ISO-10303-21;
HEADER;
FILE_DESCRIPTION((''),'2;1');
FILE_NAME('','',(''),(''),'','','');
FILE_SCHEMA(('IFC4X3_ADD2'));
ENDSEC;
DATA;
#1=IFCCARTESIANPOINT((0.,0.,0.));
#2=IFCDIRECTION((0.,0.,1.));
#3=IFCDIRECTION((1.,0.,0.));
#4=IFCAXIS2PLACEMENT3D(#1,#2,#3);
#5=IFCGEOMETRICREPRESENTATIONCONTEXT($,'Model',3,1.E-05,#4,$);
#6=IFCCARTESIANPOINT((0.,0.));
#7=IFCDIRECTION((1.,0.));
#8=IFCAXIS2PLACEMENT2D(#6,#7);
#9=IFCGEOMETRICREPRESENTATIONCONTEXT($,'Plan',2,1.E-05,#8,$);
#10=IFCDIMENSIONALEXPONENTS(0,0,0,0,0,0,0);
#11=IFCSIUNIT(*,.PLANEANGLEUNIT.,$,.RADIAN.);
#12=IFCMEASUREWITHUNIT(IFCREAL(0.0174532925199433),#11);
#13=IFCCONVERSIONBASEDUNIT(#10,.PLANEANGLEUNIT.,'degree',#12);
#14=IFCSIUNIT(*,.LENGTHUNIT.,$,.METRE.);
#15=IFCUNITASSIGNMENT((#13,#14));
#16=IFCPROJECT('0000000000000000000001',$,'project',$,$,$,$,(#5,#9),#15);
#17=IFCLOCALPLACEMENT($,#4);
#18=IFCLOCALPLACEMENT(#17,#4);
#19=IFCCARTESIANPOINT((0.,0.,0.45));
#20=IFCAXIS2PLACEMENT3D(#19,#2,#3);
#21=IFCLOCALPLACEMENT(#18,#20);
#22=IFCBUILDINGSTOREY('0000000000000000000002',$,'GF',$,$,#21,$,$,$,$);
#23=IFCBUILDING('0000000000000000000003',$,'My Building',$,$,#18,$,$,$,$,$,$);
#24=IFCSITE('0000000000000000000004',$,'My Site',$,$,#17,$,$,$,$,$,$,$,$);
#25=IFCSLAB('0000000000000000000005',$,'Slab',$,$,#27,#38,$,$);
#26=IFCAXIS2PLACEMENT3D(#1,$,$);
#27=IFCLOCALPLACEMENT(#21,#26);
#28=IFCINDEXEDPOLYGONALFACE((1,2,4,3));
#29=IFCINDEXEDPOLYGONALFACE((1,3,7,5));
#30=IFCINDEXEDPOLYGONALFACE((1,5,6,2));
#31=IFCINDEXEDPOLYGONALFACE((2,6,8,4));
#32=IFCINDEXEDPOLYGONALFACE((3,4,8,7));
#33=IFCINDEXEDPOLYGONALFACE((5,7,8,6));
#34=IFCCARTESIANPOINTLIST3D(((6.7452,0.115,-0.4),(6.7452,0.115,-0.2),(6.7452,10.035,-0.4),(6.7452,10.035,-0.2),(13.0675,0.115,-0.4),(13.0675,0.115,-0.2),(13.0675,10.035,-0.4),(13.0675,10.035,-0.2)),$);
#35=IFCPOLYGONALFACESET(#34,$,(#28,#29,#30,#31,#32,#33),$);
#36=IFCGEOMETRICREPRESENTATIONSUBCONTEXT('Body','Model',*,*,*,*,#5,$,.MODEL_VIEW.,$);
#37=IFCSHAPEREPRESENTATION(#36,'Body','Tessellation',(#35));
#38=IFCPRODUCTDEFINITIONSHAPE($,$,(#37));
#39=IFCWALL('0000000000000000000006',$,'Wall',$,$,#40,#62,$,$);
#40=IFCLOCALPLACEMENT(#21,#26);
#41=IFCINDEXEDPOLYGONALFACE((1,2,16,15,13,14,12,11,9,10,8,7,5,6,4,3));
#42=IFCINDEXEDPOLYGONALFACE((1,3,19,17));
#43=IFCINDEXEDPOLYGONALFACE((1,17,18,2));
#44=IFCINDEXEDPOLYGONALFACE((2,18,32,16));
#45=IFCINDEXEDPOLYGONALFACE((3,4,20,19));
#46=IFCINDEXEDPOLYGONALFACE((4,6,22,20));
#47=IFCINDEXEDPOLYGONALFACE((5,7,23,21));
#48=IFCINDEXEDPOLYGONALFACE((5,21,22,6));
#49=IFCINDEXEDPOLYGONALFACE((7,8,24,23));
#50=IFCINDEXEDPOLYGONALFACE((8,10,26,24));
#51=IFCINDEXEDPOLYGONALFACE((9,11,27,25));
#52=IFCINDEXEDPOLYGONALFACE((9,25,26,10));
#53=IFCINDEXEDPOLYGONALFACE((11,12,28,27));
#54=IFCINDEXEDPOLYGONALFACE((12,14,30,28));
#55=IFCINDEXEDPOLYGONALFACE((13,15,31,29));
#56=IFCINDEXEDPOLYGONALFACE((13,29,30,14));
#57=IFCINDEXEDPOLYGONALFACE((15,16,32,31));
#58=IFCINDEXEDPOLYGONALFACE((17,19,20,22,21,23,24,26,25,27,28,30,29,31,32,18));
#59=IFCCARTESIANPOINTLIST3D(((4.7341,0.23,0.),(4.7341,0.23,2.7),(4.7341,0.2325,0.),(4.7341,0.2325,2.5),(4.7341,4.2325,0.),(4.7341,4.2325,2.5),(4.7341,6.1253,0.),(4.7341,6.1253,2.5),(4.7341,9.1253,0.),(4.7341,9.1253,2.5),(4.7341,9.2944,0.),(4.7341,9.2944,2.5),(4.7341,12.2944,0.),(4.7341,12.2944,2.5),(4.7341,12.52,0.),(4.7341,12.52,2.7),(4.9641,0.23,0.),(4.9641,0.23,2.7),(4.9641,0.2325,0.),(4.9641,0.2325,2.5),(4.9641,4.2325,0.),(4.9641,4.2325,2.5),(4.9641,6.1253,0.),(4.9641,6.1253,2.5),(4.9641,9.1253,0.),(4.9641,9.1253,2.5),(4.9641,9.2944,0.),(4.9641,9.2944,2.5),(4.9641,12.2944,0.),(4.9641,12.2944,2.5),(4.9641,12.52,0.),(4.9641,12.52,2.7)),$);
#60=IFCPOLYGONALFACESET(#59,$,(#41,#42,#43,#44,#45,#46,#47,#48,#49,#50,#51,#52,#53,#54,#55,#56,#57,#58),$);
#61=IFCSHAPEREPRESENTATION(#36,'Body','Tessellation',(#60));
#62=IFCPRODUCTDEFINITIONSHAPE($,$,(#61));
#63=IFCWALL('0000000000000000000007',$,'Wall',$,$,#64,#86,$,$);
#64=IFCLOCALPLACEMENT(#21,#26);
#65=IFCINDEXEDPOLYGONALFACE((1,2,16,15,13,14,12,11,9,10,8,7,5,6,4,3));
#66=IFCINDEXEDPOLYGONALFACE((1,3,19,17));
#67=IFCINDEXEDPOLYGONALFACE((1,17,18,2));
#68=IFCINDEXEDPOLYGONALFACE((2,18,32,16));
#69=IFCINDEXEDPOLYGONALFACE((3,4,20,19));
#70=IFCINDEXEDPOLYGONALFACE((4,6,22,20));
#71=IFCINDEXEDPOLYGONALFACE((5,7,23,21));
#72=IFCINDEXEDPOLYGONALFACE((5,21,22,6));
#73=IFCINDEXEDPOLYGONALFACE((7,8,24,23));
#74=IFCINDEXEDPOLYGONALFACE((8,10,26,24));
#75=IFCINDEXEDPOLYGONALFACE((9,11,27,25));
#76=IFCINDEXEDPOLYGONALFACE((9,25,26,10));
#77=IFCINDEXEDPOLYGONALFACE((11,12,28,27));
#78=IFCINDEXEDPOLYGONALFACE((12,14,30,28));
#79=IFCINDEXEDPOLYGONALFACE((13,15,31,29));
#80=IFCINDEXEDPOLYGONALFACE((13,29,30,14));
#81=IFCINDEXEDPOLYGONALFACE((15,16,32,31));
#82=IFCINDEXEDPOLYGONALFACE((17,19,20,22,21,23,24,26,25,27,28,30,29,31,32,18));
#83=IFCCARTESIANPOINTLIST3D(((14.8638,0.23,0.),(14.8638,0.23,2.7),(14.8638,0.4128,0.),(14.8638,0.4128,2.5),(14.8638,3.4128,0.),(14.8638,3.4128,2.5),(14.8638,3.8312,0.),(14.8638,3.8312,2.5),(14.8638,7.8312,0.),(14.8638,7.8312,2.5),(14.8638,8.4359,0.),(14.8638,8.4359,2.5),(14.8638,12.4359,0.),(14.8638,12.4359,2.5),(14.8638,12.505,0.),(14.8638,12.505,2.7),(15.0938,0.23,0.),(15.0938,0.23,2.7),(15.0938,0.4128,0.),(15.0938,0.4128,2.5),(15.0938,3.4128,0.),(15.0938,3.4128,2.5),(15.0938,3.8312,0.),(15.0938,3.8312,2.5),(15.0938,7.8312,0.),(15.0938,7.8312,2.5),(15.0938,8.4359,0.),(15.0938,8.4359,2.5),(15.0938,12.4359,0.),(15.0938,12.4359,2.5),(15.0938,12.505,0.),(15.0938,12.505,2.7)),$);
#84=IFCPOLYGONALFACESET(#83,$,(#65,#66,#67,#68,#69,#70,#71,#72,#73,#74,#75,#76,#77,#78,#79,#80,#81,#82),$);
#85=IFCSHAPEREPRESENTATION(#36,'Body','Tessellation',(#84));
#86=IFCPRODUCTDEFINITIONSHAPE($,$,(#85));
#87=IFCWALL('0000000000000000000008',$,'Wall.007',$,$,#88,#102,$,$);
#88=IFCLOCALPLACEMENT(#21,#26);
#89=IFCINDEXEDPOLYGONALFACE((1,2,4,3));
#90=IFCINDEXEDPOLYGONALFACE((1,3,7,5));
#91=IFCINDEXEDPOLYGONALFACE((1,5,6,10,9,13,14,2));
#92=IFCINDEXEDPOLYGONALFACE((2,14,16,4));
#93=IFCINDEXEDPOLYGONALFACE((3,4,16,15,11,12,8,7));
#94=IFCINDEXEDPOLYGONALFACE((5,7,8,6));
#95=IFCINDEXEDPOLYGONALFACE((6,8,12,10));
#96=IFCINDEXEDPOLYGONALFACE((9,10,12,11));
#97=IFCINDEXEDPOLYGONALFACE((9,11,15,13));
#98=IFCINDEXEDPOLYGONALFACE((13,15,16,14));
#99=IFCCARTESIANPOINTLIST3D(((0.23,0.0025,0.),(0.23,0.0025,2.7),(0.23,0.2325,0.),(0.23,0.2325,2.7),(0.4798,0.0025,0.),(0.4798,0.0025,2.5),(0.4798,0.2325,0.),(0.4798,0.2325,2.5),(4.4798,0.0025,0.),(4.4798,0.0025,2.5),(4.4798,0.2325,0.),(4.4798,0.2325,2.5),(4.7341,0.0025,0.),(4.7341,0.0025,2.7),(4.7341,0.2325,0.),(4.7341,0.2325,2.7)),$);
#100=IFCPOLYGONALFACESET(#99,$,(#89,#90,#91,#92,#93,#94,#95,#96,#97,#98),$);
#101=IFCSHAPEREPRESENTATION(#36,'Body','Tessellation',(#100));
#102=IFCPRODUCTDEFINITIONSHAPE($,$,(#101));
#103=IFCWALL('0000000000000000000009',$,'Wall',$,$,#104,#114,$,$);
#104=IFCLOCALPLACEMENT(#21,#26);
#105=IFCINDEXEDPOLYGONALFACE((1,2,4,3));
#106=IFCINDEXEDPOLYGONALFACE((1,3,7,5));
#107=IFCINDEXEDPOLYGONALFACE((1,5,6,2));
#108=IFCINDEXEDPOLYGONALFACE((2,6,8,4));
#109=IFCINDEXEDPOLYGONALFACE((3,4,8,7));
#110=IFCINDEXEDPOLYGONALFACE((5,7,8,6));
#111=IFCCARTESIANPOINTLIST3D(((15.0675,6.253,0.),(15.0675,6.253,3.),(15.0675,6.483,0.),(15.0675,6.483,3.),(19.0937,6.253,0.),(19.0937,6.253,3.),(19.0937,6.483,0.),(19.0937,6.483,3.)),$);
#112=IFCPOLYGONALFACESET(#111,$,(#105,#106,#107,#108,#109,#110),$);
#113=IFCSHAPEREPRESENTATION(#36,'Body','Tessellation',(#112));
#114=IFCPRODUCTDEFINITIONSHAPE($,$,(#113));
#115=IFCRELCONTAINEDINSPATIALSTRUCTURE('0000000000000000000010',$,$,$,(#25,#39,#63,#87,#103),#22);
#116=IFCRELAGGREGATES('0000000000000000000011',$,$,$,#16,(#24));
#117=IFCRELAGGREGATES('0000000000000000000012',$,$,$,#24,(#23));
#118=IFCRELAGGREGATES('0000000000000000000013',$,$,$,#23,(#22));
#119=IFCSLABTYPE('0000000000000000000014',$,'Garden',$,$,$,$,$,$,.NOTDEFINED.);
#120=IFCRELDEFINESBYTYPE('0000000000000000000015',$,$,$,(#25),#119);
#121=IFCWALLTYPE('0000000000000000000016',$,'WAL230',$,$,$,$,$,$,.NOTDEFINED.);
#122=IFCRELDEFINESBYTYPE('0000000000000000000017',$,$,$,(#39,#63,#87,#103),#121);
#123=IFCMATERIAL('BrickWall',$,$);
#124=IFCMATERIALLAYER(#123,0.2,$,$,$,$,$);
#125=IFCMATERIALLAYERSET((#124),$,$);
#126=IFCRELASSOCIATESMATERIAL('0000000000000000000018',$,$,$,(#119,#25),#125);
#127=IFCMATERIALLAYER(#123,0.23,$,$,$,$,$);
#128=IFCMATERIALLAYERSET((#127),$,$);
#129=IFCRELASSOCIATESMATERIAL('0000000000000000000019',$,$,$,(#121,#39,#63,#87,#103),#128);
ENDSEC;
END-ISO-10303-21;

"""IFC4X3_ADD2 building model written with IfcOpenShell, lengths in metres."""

from ifc_helpers import new_model, entity, si_unit, converted_unit, frame, origin_with_axes, origin_2d_with_axis, place, context, subcontext, project, spatial, line, indexed_curve, outline, extrude, source, transform, mapped, material, layer, layer_set, layer_usage, type_object, element, save


model = new_model("IFC4X3_ADD2")

# Units and contexts
model_context = context("Model", 3, precision=1e-05, world=origin_with_axes())
plan_context = context("Plan", 2, precision=1e-05, world=origin_2d_with_axis())
body_context_1 = subcontext(model_context, "Body", "Model", "MODEL_VIEW")
ifc_project = project(units=[converted_unit("PLANEANGLEUNIT", "degree", entity("IfcReal", 0.0174532925199433), si_unit("PLANEANGLEUNIT", "RADIAN"), dimensions=[0, 0, 0, 0, 0, 0, 0]), si_unit("LENGTHUNIT", "METRE")], contexts=[model_context, plan_context])

# Site, building, storey
site_placement = place(None, origin_with_axes())
site = spatial("IfcSite", under=ifc_project, at=site_placement, Name="My Site")
building_placement = place(site_placement, origin_with_axes())
building = spatial("IfcBuilding", under=site, at=building_placement, Name="My Building")
storey_placement = place(building_placement, frame((0.0, 0.0, 0.45), z_axis=(0.0, 0.0, 1.0), x_axis=(1.0, 0.0, 0.0)))
storey = spatial("IfcBuildingStorey", under=building, at=storey_placement, Name="GF")

# Slab
ifc_material = material(Name="BrickWall")
ifc_layer_1 = layer(ifc_material, 0.2)
ifc_layer_set_1 = layer_set([ifc_layer_1])
ifc_layer_usage_1 = layer_usage(ifc_layer_set_1, "AXIS3", "POSITIVE", 0.0)
slab_type = type_object("IfcSlabType", Name="Garden", PredefinedType="NOTDEFINED", material=ifc_layer_set_1)
slab_placement = place(storey_placement, frame((6.7452, 0.115, -0.4), z_axis=(0.0, 0.0, 1.0), x_axis=(1.0, 0.0, 0.0)))
element("IfcSlab", 1, at=slab_placement, inside=storey, type_object=slab_type, material=ifc_layer_usage_1, Name="Slab", context=body_context_1, shape_type="SweptSolid", body=[
    extrude(outline(indexed_curve([(0.0, 9.92), (0.0, 0.0), (6.3223, 0.0), (6.3223, 9.92)], segments=[line(4, 1), line(1, 2), line(2, 3), line(3, 4)], self_intersect=False)), None, (0.0, 0.0, 1.0), 0.2),
])

# Walls, openings
ifc_layer_2 = layer(ifc_material, 0.23)
ifc_layer_set_2 = layer_set([ifc_layer_2])
ifc_layer_usage_2 = layer_usage(ifc_layer_set_2, "AXIS2", "POSITIVE", 0.0)
wall_type_1 = type_object("IfcWallType", Name="WAL230", PredefinedType="NOTDEFINED", material=ifc_layer_set_2)
wall_1_placement = place(storey_placement, frame((4.9641, 0.23, 0.0), z_axis=(0.0, 0.0, 1.0), x_axis=(0.0, 1.0, 0.0)))
wall_1 = element("IfcWall", 2, at=wall_1_placement, inside=storey, type_object=wall_type_1, material=ifc_layer_usage_2, Name="Wall", context=body_context_1, shape_type="SweptSolid", body=[
    extrude(outline(indexed_curve([(0.0, 0.0), (0.0, 0.23), (12.29, 0.23), (12.29, 0.0), (0.0, 0.0)], self_intersect=False)), origin_with_axes(), (0.0, 0.0, 1.0), 2.7),
])
shared_shape_1 = source(origin_with_axes(), body_context_1, "Body", "SweptSolid", [
    extrude(outline(indexed_curve([(0.0, 0.0), (4.0, 0.0), (4.0, 2.5), (0.0, 2.5)], segments=[line(1, 2, 3, 4, 1)])), frame((0.0, -0.6, 0.0), z_axis=(0.0, -1.0, 0.0), x_axis=(1.0, 0.0, 0.0)), (0.0, 0.0, -1.0), 1.2),
])
opening_1_placement = place(wall_1_placement, frame((0.0025, 0.0, 0.0), z_axis=(0.0, 0.0, 1.0), x_axis=(1.0, 0.0, 0.0)))
element("IfcOpeningElement", 3, at=opening_1_placement, cuts=wall_1, PredefinedType="OPENING", context=body_context_1, shape_type="MappedRepresentation", body=[
    mapped(shared_shape_1, transform((0.0, 0.0, 0.0), x_axis=(1.0, 0.0, 0.0), y_axis=(0.0, 1.0, 0.0), z_axis=(0.0, 0.0, 1.0), scale=1.0)),
])
shared_shape_2 = source(origin_with_axes(), body_context_1, "Body", "SweptSolid", [
    extrude(outline(indexed_curve([(0.0, 0.0), (3.0, 0.0), (3.0, 2.5), (0.0, 2.5)], segments=[line(1, 2, 3, 4, 1)])), frame((0.0, -0.6, 0.0), z_axis=(0.0, -1.0, 0.0), x_axis=(1.0, 0.0, 0.0)), (0.0, 0.0, -1.0), 1.2),
])
opening_2_placement = place(wall_1_placement, frame((9.0644, 0.0, 0.0), z_axis=(0.0, 0.0, 1.0), x_axis=(1.0, 0.0, 0.0)))
element("IfcOpeningElement", 4, at=opening_2_placement, cuts=wall_1, PredefinedType="OPENING", context=body_context_1, shape_type="MappedRepresentation", body=[
    mapped(shared_shape_2, transform((0.0, 0.0, 0.0), x_axis=(1.0, 0.0, 0.0), y_axis=(0.0, 1.0, 0.0), z_axis=(0.0, 0.0, 1.0), scale=1.0)),
])
opening_3_placement = place(wall_1_placement, frame((5.8953, 0.0, 0.0), z_axis=(0.0, 0.0, 1.0), x_axis=(1.0, 0.0, 0.0)))
element("IfcOpeningElement", 5, at=opening_3_placement, cuts=wall_1, PredefinedType="OPENING", context=body_context_1, shape_type="MappedRepresentation", body=[
    mapped(shared_shape_2, transform((0.0, 0.0, 0.0), x_axis=(1.0, 0.0, 0.0), y_axis=(0.0, 1.0, 0.0), z_axis=(0.0, 0.0, 1.0), scale=1.0)),
])
ifc_layer_usage_3 = layer_usage(ifc_layer_set_2, "AXIS2", "POSITIVE", 0.0)
wall_2_placement = place(storey_placement, frame((15.0938, 0.23, 0.0), z_axis=(0.0, 0.0, 1.0), x_axis=(0.0, 1.0, 0.0)))
wall_2 = element("IfcWall", 6, at=wall_2_placement, inside=storey, type_object=wall_type_1, material=ifc_layer_usage_3, Name="Wall", context=body_context_1, shape_type="SweptSolid", body=[
    extrude(outline(indexed_curve([(0.0, 0.0), (0.0, 0.23), (12.275, 0.23), (12.275, 0.0), (0.0, 0.0)], self_intersect=False)), origin_with_axes(), (0.0, 0.0, 1.0), 2.7),
])
opening_4_placement = place(wall_2_placement, frame((8.2059, 0.0, 0.0), z_axis=(0.0, 0.0, 1.0), x_axis=(1.0, 0.0, 0.0)))
element("IfcOpeningElement", 7, at=opening_4_placement, cuts=wall_2, PredefinedType="OPENING", context=body_context_1, shape_type="MappedRepresentation", body=[
    mapped(shared_shape_1, transform((0.0, 0.0, 0.0), x_axis=(1.0, 0.0, 0.0), y_axis=(0.0, 1.0, 0.0), z_axis=(0.0, 0.0, 1.0), scale=1.0)),
])
opening_5_placement = place(wall_2_placement, frame((3.6012, 0.0, 0.0), z_axis=(0.0, 0.0, 1.0), x_axis=(1.0, 0.0, 0.0)))
element("IfcOpeningElement", 8, at=opening_5_placement, cuts=wall_2, PredefinedType="OPENING", context=body_context_1, shape_type="MappedRepresentation", body=[
    mapped(shared_shape_1, transform((0.0, 0.0, 0.0), x_axis=(1.0, 0.0, 0.0), y_axis=(0.0, 1.0, 0.0), z_axis=(0.0, 0.0, 1.0), scale=1.0)),
])
opening_6_placement = place(wall_2_placement, frame((0.1828, 0.0, 0.0), z_axis=(0.0, 0.0, 1.0), x_axis=(1.0, 0.0, 0.0)))
element("IfcOpeningElement", 9, at=opening_6_placement, cuts=wall_2, PredefinedType="OPENING", context=body_context_1, shape_type="MappedRepresentation", body=[
    mapped(shared_shape_2, transform((0.0, 0.0, 0.0), x_axis=(1.0, 0.0, 0.0), y_axis=(0.0, 1.0, 0.0), z_axis=(0.0, 0.0, 1.0), scale=1.0)),
])

# Wall, opening
ifc_layer_usage_4 = layer_usage(ifc_layer_set_2, "AXIS2", "POSITIVE", 0.0)
wall_3_placement = place(storey_placement, frame((4.7341, 0.2325, 0.0), z_axis=(0.0, 0.0, 1.0), x_axis=(-1.0, 0.0, 0.0)))
wall_3 = element("IfcWall", 10, at=wall_3_placement, inside=storey, type_object=wall_type_1, material=ifc_layer_usage_4, Name="Wall.007", context=body_context_1, shape_type="SweptSolid", body=[
    extrude(outline(indexed_curve([(0.0, 0.0), (0.0, 0.23), (4.5041, 0.23), (4.5041, 0.0), (0.0, 0.0)], self_intersect=False)), origin_with_axes(), (0.0, 0.0, 1.0), 2.7),
])
opening_7_placement = place(wall_3_placement, frame((0.2543, 0.0, 0.0), z_axis=(0.0, 0.0, 1.0), x_axis=(1.0, 0.0, 0.0)))
element("IfcOpeningElement", 11, at=opening_7_placement, cuts=wall_3, PredefinedType="OPENING", context=body_context_1, shape_type="MappedRepresentation", body=[
    mapped(shared_shape_1, transform((0.0, 0.0, 0.0), x_axis=(1.0, 0.0, 0.0), y_axis=(0.0, 1.0, 0.0), z_axis=(0.0, 0.0, 1.0), scale=1.0)),
])

# Wall
ifc_layer_usage_5 = layer_usage(ifc_layer_set_2, "AXIS2", "POSITIVE", 0.0)
wall_4_placement = place(storey_placement, frame((15.0675, 6.253, 0.0), z_axis=(0.0, 0.0, 1.0), x_axis=(1.0, 0.0, 0.0)))
element("IfcWall", 12, at=wall_4_placement, inside=storey, type_object=wall_type_1, material=ifc_layer_usage_5, Name="Wall", context=body_context_1, shape_type="SweptSolid", body=[
    extrude(outline(indexed_curve([(0.0, 0.0), (0.0, 0.23), (4.0262, 0.23), (4.0262, 0.0), (0.0, 0.0)], self_intersect=False)), origin_with_axes(), (0.0, 0.0, 1.0), 3.0),
])

save(model, "model.ifc")
